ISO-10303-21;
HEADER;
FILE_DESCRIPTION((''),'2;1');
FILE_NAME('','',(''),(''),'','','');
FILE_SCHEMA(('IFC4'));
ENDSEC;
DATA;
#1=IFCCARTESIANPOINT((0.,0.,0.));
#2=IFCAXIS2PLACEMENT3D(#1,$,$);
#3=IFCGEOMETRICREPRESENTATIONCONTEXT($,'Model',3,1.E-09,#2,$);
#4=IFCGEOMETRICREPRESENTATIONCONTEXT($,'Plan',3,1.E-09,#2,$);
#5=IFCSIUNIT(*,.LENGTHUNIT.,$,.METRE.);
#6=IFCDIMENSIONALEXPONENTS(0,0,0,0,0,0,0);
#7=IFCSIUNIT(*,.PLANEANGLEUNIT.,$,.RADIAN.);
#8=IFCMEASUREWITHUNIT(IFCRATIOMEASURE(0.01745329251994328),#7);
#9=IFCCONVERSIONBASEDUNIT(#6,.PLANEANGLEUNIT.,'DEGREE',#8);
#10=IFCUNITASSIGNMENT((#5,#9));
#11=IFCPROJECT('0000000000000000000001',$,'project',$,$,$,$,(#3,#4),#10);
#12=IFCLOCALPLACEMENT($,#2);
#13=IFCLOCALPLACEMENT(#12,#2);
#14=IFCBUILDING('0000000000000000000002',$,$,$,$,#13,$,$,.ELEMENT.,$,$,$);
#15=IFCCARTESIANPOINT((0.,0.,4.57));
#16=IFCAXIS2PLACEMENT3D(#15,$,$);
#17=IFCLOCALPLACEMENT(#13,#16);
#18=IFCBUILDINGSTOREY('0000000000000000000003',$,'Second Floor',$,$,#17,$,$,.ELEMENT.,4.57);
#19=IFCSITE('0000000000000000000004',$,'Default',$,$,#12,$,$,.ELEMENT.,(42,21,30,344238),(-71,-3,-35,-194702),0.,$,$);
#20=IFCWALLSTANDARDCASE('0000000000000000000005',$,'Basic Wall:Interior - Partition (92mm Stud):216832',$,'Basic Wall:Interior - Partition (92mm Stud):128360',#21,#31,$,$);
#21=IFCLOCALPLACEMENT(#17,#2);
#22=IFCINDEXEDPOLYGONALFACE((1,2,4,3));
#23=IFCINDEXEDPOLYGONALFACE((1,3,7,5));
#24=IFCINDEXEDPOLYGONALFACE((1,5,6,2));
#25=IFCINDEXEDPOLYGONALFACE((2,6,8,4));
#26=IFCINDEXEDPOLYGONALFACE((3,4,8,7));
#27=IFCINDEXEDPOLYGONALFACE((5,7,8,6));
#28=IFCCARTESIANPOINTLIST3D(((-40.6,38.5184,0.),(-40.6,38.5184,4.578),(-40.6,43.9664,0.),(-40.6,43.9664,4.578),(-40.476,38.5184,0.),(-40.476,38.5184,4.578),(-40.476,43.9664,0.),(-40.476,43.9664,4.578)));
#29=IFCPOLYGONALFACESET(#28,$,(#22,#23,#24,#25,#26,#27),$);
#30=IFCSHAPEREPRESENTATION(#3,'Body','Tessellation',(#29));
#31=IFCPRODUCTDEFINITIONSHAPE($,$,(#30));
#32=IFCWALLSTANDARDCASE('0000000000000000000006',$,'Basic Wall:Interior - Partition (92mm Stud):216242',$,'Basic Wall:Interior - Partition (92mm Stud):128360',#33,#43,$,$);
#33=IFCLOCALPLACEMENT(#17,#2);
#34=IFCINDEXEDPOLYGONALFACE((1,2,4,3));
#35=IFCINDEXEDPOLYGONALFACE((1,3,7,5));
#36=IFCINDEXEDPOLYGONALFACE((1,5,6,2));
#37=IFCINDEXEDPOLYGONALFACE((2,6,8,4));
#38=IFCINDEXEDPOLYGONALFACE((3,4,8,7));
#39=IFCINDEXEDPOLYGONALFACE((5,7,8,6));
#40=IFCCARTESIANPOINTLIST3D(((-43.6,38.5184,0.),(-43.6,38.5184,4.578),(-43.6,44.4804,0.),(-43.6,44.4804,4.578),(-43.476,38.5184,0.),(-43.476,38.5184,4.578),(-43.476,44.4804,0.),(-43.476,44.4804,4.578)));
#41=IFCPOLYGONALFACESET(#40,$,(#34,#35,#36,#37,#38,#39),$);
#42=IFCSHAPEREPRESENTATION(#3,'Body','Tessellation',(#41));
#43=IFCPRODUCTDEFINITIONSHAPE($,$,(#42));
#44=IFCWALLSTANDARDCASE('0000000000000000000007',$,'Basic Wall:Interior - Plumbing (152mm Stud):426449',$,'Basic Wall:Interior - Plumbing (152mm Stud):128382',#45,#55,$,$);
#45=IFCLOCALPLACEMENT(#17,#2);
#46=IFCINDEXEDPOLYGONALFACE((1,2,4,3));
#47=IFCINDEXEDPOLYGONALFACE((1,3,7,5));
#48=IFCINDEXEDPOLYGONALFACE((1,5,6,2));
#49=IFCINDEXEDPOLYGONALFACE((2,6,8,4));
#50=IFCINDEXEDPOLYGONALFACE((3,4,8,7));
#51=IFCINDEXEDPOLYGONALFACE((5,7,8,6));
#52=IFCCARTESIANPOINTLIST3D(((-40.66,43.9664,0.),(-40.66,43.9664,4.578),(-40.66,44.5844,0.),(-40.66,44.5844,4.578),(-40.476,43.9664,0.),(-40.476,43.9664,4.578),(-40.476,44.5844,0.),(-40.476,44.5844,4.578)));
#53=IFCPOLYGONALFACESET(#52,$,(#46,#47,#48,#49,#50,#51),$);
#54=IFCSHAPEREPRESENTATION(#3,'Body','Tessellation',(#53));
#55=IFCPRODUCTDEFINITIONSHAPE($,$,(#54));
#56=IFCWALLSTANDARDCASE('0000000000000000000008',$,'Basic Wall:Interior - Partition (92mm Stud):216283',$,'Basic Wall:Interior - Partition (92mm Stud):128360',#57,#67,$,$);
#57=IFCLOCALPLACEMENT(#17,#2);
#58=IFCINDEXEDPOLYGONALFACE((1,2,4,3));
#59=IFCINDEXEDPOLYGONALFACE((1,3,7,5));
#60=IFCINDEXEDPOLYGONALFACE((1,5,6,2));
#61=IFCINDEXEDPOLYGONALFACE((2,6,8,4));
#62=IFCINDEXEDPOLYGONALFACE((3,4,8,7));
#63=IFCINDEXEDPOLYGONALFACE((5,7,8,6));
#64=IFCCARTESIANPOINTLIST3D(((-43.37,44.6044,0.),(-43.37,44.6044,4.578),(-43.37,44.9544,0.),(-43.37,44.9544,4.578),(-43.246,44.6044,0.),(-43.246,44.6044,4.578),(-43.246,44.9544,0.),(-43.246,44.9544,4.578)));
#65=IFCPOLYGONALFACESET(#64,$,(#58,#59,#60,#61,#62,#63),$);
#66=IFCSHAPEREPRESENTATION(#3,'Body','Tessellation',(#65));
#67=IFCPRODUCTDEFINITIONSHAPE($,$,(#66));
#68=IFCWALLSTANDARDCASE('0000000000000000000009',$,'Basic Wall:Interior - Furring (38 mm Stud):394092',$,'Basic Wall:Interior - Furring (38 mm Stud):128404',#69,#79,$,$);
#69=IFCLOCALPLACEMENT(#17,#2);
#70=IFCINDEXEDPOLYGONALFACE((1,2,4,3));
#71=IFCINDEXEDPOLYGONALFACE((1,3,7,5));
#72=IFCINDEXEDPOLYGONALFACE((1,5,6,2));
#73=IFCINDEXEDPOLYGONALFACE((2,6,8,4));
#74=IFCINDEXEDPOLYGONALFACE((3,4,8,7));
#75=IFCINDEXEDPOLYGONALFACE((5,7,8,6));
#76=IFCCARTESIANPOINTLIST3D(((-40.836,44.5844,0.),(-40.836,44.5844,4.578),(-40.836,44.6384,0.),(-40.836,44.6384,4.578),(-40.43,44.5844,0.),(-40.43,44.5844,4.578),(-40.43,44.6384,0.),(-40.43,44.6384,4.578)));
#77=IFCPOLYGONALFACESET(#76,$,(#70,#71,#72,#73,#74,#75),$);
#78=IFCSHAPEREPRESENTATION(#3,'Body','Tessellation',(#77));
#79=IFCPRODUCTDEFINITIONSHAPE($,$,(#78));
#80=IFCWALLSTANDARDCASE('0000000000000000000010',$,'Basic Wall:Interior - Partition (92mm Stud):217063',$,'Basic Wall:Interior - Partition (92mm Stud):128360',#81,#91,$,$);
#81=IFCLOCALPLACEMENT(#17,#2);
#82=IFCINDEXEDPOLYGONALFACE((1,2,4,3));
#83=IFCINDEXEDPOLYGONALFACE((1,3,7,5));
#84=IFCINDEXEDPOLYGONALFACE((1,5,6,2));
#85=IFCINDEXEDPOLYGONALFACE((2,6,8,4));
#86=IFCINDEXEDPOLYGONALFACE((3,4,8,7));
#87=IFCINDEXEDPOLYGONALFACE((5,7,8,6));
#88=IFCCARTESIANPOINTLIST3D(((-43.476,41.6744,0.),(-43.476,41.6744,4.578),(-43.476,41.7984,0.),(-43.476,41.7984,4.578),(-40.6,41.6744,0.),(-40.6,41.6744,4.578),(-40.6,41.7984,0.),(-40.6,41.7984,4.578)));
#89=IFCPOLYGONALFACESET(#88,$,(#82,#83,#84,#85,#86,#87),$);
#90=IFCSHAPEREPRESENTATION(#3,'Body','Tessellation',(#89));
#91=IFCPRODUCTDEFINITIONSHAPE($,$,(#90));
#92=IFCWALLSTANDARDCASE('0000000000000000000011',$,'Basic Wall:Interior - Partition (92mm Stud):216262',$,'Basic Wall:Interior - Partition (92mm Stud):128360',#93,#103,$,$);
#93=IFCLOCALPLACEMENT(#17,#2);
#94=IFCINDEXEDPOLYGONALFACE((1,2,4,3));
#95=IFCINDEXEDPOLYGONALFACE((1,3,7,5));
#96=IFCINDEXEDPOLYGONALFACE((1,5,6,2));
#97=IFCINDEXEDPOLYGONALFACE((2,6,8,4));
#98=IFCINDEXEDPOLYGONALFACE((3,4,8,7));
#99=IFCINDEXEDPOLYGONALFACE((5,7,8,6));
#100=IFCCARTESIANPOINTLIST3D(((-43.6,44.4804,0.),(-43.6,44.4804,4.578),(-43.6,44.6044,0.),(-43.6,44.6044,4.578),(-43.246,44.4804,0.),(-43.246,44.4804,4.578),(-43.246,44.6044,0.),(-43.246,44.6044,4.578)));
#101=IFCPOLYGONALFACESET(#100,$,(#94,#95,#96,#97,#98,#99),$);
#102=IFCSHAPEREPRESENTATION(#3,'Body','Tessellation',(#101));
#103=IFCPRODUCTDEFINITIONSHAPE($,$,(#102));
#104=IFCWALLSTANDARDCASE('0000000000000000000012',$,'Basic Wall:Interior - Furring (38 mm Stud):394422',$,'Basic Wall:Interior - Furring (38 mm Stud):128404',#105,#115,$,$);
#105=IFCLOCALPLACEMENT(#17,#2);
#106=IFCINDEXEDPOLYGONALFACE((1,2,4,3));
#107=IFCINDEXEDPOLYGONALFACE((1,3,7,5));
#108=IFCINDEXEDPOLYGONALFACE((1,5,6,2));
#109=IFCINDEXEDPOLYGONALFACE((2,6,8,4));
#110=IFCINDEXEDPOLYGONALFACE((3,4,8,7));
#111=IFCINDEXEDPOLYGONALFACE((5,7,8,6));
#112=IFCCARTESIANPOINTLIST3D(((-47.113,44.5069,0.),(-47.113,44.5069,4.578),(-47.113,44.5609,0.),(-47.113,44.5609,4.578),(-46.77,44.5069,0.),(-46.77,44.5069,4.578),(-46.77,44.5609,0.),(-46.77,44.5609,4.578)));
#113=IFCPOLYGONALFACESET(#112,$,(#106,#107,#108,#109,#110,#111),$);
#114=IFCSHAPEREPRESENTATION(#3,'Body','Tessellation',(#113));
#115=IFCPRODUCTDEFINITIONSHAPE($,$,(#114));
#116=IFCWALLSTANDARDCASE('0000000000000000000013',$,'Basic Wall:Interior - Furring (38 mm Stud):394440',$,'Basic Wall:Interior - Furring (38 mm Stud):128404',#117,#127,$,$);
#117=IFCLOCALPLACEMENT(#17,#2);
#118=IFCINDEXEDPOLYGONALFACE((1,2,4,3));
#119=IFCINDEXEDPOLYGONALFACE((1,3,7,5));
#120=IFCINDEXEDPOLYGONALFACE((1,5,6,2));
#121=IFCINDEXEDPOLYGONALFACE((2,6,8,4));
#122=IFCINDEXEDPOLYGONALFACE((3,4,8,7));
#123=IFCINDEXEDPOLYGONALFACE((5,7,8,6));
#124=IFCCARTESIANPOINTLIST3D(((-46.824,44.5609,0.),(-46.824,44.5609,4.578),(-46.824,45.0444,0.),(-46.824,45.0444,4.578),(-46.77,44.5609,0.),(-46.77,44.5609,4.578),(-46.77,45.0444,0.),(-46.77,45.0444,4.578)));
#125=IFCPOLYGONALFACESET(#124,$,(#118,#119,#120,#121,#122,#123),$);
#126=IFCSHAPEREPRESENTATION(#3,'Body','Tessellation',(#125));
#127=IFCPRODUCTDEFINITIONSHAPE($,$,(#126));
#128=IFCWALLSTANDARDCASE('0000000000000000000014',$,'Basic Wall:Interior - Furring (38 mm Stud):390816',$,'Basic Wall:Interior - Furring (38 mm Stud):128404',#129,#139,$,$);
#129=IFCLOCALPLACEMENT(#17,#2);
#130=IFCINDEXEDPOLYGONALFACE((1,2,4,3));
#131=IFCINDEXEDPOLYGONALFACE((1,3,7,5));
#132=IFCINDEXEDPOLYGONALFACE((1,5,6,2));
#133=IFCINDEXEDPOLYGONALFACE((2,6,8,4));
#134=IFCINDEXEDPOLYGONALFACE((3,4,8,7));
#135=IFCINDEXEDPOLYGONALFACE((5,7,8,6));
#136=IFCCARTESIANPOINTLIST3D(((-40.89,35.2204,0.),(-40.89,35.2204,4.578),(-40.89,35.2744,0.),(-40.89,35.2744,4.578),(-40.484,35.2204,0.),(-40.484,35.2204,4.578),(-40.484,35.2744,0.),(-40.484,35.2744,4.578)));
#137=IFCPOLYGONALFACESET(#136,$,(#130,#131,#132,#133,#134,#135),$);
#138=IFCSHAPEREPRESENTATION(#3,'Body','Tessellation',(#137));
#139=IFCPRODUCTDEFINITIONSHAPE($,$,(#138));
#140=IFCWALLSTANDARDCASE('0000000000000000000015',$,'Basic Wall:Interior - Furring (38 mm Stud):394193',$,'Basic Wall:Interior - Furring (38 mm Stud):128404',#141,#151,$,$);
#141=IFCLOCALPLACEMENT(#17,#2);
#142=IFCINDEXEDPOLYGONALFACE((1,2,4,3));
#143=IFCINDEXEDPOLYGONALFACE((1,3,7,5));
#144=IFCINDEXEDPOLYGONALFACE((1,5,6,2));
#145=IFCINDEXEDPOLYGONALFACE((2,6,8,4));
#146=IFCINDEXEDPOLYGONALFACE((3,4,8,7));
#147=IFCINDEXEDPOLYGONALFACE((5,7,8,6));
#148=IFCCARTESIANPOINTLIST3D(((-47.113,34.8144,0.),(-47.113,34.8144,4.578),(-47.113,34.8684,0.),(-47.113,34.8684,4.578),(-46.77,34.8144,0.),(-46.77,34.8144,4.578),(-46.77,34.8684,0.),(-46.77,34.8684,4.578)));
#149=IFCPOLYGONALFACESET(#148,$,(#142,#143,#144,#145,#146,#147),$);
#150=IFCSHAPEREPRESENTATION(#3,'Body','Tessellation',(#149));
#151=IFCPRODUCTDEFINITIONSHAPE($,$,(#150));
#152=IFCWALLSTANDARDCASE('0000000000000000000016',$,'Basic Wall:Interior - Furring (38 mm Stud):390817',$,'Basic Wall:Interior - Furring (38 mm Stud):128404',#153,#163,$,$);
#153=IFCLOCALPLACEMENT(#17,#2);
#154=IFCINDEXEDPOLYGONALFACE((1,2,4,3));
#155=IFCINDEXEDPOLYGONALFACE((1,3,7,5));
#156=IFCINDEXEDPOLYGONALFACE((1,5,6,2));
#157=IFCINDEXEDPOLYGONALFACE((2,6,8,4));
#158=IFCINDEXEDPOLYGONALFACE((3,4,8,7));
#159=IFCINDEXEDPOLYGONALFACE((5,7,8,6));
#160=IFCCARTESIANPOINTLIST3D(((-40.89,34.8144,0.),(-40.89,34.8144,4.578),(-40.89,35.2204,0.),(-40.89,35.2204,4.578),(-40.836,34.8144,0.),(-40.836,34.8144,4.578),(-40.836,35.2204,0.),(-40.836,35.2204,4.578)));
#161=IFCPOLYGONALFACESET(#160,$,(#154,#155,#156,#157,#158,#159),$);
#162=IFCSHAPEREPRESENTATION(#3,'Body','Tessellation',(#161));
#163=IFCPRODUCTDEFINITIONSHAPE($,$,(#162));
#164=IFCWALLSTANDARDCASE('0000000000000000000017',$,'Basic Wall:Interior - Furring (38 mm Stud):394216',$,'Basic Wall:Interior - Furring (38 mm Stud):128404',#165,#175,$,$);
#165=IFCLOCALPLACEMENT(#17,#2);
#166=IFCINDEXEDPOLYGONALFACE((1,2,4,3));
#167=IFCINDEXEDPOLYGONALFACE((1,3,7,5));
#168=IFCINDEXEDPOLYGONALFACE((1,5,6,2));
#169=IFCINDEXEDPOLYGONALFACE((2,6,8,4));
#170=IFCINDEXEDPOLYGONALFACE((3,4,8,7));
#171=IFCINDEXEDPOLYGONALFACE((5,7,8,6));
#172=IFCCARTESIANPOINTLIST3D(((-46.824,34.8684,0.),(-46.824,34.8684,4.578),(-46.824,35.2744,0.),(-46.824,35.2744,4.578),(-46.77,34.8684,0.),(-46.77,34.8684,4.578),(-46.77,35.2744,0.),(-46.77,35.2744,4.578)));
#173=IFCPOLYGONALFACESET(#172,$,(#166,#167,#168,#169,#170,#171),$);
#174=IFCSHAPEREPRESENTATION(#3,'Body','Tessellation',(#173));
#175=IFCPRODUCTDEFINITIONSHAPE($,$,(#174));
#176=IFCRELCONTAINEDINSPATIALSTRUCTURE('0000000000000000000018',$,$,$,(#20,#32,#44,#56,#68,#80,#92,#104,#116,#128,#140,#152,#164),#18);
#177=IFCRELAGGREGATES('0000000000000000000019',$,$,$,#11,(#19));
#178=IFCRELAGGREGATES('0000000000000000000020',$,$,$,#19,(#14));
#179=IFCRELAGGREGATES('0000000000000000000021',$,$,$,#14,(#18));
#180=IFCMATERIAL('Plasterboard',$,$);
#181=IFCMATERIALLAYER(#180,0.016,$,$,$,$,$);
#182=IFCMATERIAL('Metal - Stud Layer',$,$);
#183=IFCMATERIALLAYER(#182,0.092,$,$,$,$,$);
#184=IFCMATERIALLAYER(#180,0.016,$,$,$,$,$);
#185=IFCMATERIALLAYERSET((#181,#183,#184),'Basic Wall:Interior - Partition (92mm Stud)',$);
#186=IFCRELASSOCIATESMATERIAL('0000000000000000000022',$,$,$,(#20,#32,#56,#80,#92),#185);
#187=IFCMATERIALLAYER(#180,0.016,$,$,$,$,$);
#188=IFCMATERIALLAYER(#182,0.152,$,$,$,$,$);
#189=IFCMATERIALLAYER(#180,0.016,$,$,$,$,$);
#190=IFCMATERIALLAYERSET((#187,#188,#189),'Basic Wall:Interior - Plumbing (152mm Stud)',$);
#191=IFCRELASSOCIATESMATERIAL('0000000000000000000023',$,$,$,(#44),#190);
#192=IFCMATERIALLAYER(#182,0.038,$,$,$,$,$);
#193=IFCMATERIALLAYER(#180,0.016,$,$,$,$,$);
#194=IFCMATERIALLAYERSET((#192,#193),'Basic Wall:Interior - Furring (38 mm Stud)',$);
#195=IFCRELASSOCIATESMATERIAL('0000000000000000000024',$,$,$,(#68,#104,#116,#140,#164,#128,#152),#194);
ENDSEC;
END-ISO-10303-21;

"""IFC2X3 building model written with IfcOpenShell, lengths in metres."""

from ifc_helpers import new_model, entity, si_unit, converted_unit, frame, frame_2d, origin, place, context, project, spatial, rectangle, extrude, material, layer, layer_set, layer_usage, element, save


model = new_model("IFC2X3")

# Units and contexts
model_context = context("Model", 3, precision=1e-09, world=origin())
plan_context = context("Plan", 3, precision=1e-09, world=origin())
ifc_project = project(units=[si_unit("LENGTHUNIT", "METRE"), converted_unit("PLANEANGLEUNIT", "DEGREE", entity("IfcRatioMeasure", 0.01745329251994328), si_unit("PLANEANGLEUNIT", "RADIAN"), dimensions=[0, 0, 0, 0, 0, 0, 0])], contexts=[model_context, plan_context])

# Site, building, storey
site_placement = place(None, origin())
site = spatial("IfcSite", under=ifc_project, at=site_placement, Name="Default", CompositionType="ELEMENT", RefLatitude=(42, 21, 30, 344238), RefLongitude=(-71, -3, -35, -194702), RefElevation=0.0)
building_placement = place(site_placement, origin())
building = spatial("IfcBuilding", under=site, at=building_placement, CompositionType="ELEMENT")
storey_placement = place(building_placement, frame((0.0, 0.0, 4.57)))
storey = spatial("IfcBuildingStorey", under=building, at=storey_placement, Name="Second Floor", CompositionType="ELEMENT", Elevation=4.57)

# Walls
ifc_material_1 = material(Name="Plasterboard")
ifc_layer_1 = layer(ifc_material_1, 0.016)
ifc_material_2 = material(Name="Metal - Stud Layer")
ifc_layer_2 = layer(ifc_material_2, 0.092)
ifc_layer_3 = layer(ifc_material_1, 0.016)
ifc_layer_set_1 = layer_set([ifc_layer_1, ifc_layer_2, ifc_layer_3], Name="Basic Wall:Interior - Partition (92mm Stud)")
ifc_layer_usage_1 = layer_usage(ifc_layer_set_1, "AXIS2", "NEGATIVE", 0.062)
wall_1_placement = place(storey_placement, frame((-40.538, 38.5184, 0.0), z_axis=(0.0, 0.0, 1.0), x_axis=(0.0, 1.0, 0.0)))
element("IfcWallStandardCase", 1, at=wall_1_placement, inside=storey, material=ifc_layer_usage_1, Name="Basic Wall:Interior - Partition (92mm Stud):216832", ObjectType="Basic Wall:Interior - Partition (92mm Stud):128360", context=model_context, shape_type="SweptSolid", body=[
    extrude(rectangle(XDim=5.448, YDim=0.124, at=frame_2d((2.724, 0.0), x_axis=(-1.0, 0.0))), origin(), (0.0, 0.0, 1.0), 4.578),
])
wall_2_placement = place(storey_placement, frame((-43.538, 38.5184, 0.0), z_axis=(0.0, 0.0, 1.0), x_axis=(0.0, 1.0, 0.0)))
element("IfcWallStandardCase", 2, at=wall_2_placement, inside=storey, material=ifc_layer_usage_1, Name="Basic Wall:Interior - Partition (92mm Stud):216242", ObjectType="Basic Wall:Interior - Partition (92mm Stud):128360", context=model_context, shape_type="SweptSolid", body=[
    extrude(rectangle(XDim=5.962, YDim=0.124, at=frame_2d((2.981, 0.0), x_axis=(-1.0, 0.0))), origin(), (0.0, 0.0, 1.0), 4.578),
])
ifc_layer_4 = layer(ifc_material_1, 0.016)
ifc_layer_5 = layer(ifc_material_2, 0.152)
ifc_layer_6 = layer(ifc_material_1, 0.016)
ifc_layer_set_2 = layer_set([ifc_layer_4, ifc_layer_5, ifc_layer_6], Name="Basic Wall:Interior - Plumbing (152mm Stud)")
ifc_layer_usage_2 = layer_usage(ifc_layer_set_2, "AXIS2", "NEGATIVE", 0.092)
wall_3_placement = place(storey_placement, frame((-40.568, 43.9664, 0.0), z_axis=(0.0, 0.0, 1.0), x_axis=(0.0, 1.0, 0.0)))
element("IfcWallStandardCase", 3, at=wall_3_placement, inside=storey, material=ifc_layer_usage_2, Name="Basic Wall:Interior - Plumbing (152mm Stud):426449", ObjectType="Basic Wall:Interior - Plumbing (152mm Stud):128382", context=model_context, shape_type="SweptSolid", body=[
    extrude(rectangle(XDim=0.618, YDim=0.184, at=frame_2d((0.309, 0.0), x_axis=(-1.0, 0.0))), origin(), (0.0, 0.0, 1.0), 4.578),
])
wall_4_placement = place(storey_placement, frame((-43.308, 44.6044, 0.0), z_axis=(0.0, 0.0, 1.0), x_axis=(0.0, 1.0, 0.0)))
element("IfcWallStandardCase", 4, at=wall_4_placement, inside=storey, material=ifc_layer_usage_1, Name="Basic Wall:Interior - Partition (92mm Stud):216283", ObjectType="Basic Wall:Interior - Partition (92mm Stud):128360", context=model_context, shape_type="SweptSolid", body=[
    extrude(rectangle(XDim=0.35, YDim=0.124, at=frame_2d((0.175, 0.0), x_axis=(-1.0, 0.0))), origin(), (0.0, 0.0, 1.0), 4.578),
])
ifc_layer_7 = layer(ifc_material_2, 0.038)
ifc_layer_8 = layer(ifc_material_1, 0.016)
ifc_layer_set_3 = layer_set([ifc_layer_7, ifc_layer_8], Name="Basic Wall:Interior - Furring (38 mm Stud)")
ifc_layer_usage_3 = layer_usage(ifc_layer_set_3, "AXIS2", "NEGATIVE", 0.027)
wall_5_placement = place(storey_placement, frame((-40.836, 44.6114, 0.0)))
element("IfcWallStandardCase", 5, at=wall_5_placement, inside=storey, material=ifc_layer_usage_3, Name="Basic Wall:Interior - Furring (38 mm Stud):394092", ObjectType="Basic Wall:Interior - Furring (38 mm Stud):128404", context=model_context, shape_type="SweptSolid", body=[
    extrude(rectangle(XDim=0.406, YDim=0.054, at=frame_2d((0.203, 0.0), x_axis=(-1.0, 0.0))), origin(), (0.0, 0.0, 1.0), 4.578),
])
wall_6_placement = place(storey_placement, frame((-40.6, 41.7364, 0.0), z_axis=(0.0, 0.0, 1.0), x_axis=(-1.0, 0.0, 0.0)))
element("IfcWallStandardCase", 6, at=wall_6_placement, inside=storey, material=ifc_layer_usage_1, Name="Basic Wall:Interior - Partition (92mm Stud):217063", ObjectType="Basic Wall:Interior - Partition (92mm Stud):128360", context=model_context, shape_type="SweptSolid", body=[
    extrude(rectangle(XDim=2.876, YDim=0.124, at=frame_2d((1.438, 0.0), x_axis=(-1.0, 0.0))), origin(), (0.0, 0.0, 1.0), 4.578),
])
wall_7_placement = place(storey_placement, frame((-43.6, 44.5424, 0.0)))
element("IfcWallStandardCase", 7, at=wall_7_placement, inside=storey, material=ifc_layer_usage_1, Name="Basic Wall:Interior - Partition (92mm Stud):216262", ObjectType="Basic Wall:Interior - Partition (92mm Stud):128360", context=model_context, shape_type="SweptSolid", body=[
    extrude(rectangle(XDim=0.354, YDim=0.124, at=frame_2d((0.177, 0.0), x_axis=(-1.0, 0.0))), origin(), (0.0, 0.0, 1.0), 4.578),
])
wall_8_placement = place(storey_placement, frame((-47.113, 44.5339, 0.0)))
element("IfcWallStandardCase", 8, at=wall_8_placement, inside=storey, material=ifc_layer_usage_3, Name="Basic Wall:Interior - Furring (38 mm Stud):394422", ObjectType="Basic Wall:Interior - Furring (38 mm Stud):128404", context=model_context, shape_type="SweptSolid", body=[
    extrude(rectangle(XDim=0.343, YDim=0.054, at=frame_2d((0.1715, 0.0), x_axis=(-1.0, 0.0))), origin(), (0.0, 0.0, 1.0), 4.578),
])
wall_9_placement = place(storey_placement, frame((-46.797, 44.5609, 0.0), z_axis=(0.0, 0.0, 1.0), x_axis=(0.0, 1.0, 0.0)))
element("IfcWallStandardCase", 9, at=wall_9_placement, inside=storey, material=ifc_layer_usage_3, Name="Basic Wall:Interior - Furring (38 mm Stud):394440", ObjectType="Basic Wall:Interior - Furring (38 mm Stud):128404", context=model_context, shape_type="SweptSolid", body=[
    extrude(rectangle(XDim=0.4835, YDim=0.054, at=frame_2d((0.2418, 0.0), x_axis=(-1.0, 0.0))), origin(), (0.0, 0.0, 1.0), 4.578),
])
ifc_layer_usage_4 = layer_usage(ifc_layer_set_3, "AXIS2", "POSITIVE", -0.027)
wall_10_placement = place(storey_placement, frame((-40.89, 35.2474, 0.0)))
element("IfcWallStandardCase", 10, at=wall_10_placement, inside=storey, material=ifc_layer_usage_4, Name="Basic Wall:Interior - Furring (38 mm Stud):390816", ObjectType="Basic Wall:Interior - Furring (38 mm Stud):128404", context=model_context, shape_type="SweptSolid", body=[
    extrude(rectangle(XDim=0.406, YDim=0.054, at=frame_2d((0.203, 0.0), x_axis=(-1.0, 0.0))), origin(), (0.0, 0.0, 1.0), 4.578),
])
wall_11_placement = place(storey_placement, frame((-47.113, 34.8414, 0.0)))
element("IfcWallStandardCase", 11, at=wall_11_placement, inside=storey, material=ifc_layer_usage_3, Name="Basic Wall:Interior - Furring (38 mm Stud):394193", ObjectType="Basic Wall:Interior - Furring (38 mm Stud):128404", context=model_context, shape_type="SweptSolid", body=[
    extrude(rectangle(XDim=0.343, YDim=0.054, at=frame_2d((0.1715, 0.0), x_axis=(-1.0, 0.0))), origin(), (0.0, 0.0, 1.0), 4.578),
])
wall_12_placement = place(storey_placement, frame((-40.863, 34.8144, 0.0), z_axis=(0.0, 0.0, 1.0), x_axis=(0.0, 1.0, 0.0)))
element("IfcWallStandardCase", 12, at=wall_12_placement, inside=storey, material=ifc_layer_usage_4, Name="Basic Wall:Interior - Furring (38 mm Stud):390817", ObjectType="Basic Wall:Interior - Furring (38 mm Stud):128404", context=model_context, shape_type="SweptSolid", body=[
    extrude(rectangle(XDim=0.406, YDim=0.054, at=frame_2d((0.203, 0.0), x_axis=(-1.0, 0.0))), origin(), (0.0, 0.0, 1.0), 4.578),
])
wall_13_placement = place(storey_placement, frame((-46.797, 34.8684, 0.0), z_axis=(0.0, 0.0, 1.0), x_axis=(0.0, 1.0, 0.0)))
element("IfcWallStandardCase", 13, at=wall_13_placement, inside=storey, material=ifc_layer_usage_3, Name="Basic Wall:Interior - Furring (38 mm Stud):394216", ObjectType="Basic Wall:Interior - Furring (38 mm Stud):128404", context=model_context, shape_type="SweptSolid", body=[
    extrude(rectangle(XDim=0.406, YDim=0.054, at=frame_2d((0.203, 0.0), x_axis=(-1.0, 0.0))), origin(), (0.0, 0.0, 1.0), 4.578),
])

save(model, "model.ifc")
